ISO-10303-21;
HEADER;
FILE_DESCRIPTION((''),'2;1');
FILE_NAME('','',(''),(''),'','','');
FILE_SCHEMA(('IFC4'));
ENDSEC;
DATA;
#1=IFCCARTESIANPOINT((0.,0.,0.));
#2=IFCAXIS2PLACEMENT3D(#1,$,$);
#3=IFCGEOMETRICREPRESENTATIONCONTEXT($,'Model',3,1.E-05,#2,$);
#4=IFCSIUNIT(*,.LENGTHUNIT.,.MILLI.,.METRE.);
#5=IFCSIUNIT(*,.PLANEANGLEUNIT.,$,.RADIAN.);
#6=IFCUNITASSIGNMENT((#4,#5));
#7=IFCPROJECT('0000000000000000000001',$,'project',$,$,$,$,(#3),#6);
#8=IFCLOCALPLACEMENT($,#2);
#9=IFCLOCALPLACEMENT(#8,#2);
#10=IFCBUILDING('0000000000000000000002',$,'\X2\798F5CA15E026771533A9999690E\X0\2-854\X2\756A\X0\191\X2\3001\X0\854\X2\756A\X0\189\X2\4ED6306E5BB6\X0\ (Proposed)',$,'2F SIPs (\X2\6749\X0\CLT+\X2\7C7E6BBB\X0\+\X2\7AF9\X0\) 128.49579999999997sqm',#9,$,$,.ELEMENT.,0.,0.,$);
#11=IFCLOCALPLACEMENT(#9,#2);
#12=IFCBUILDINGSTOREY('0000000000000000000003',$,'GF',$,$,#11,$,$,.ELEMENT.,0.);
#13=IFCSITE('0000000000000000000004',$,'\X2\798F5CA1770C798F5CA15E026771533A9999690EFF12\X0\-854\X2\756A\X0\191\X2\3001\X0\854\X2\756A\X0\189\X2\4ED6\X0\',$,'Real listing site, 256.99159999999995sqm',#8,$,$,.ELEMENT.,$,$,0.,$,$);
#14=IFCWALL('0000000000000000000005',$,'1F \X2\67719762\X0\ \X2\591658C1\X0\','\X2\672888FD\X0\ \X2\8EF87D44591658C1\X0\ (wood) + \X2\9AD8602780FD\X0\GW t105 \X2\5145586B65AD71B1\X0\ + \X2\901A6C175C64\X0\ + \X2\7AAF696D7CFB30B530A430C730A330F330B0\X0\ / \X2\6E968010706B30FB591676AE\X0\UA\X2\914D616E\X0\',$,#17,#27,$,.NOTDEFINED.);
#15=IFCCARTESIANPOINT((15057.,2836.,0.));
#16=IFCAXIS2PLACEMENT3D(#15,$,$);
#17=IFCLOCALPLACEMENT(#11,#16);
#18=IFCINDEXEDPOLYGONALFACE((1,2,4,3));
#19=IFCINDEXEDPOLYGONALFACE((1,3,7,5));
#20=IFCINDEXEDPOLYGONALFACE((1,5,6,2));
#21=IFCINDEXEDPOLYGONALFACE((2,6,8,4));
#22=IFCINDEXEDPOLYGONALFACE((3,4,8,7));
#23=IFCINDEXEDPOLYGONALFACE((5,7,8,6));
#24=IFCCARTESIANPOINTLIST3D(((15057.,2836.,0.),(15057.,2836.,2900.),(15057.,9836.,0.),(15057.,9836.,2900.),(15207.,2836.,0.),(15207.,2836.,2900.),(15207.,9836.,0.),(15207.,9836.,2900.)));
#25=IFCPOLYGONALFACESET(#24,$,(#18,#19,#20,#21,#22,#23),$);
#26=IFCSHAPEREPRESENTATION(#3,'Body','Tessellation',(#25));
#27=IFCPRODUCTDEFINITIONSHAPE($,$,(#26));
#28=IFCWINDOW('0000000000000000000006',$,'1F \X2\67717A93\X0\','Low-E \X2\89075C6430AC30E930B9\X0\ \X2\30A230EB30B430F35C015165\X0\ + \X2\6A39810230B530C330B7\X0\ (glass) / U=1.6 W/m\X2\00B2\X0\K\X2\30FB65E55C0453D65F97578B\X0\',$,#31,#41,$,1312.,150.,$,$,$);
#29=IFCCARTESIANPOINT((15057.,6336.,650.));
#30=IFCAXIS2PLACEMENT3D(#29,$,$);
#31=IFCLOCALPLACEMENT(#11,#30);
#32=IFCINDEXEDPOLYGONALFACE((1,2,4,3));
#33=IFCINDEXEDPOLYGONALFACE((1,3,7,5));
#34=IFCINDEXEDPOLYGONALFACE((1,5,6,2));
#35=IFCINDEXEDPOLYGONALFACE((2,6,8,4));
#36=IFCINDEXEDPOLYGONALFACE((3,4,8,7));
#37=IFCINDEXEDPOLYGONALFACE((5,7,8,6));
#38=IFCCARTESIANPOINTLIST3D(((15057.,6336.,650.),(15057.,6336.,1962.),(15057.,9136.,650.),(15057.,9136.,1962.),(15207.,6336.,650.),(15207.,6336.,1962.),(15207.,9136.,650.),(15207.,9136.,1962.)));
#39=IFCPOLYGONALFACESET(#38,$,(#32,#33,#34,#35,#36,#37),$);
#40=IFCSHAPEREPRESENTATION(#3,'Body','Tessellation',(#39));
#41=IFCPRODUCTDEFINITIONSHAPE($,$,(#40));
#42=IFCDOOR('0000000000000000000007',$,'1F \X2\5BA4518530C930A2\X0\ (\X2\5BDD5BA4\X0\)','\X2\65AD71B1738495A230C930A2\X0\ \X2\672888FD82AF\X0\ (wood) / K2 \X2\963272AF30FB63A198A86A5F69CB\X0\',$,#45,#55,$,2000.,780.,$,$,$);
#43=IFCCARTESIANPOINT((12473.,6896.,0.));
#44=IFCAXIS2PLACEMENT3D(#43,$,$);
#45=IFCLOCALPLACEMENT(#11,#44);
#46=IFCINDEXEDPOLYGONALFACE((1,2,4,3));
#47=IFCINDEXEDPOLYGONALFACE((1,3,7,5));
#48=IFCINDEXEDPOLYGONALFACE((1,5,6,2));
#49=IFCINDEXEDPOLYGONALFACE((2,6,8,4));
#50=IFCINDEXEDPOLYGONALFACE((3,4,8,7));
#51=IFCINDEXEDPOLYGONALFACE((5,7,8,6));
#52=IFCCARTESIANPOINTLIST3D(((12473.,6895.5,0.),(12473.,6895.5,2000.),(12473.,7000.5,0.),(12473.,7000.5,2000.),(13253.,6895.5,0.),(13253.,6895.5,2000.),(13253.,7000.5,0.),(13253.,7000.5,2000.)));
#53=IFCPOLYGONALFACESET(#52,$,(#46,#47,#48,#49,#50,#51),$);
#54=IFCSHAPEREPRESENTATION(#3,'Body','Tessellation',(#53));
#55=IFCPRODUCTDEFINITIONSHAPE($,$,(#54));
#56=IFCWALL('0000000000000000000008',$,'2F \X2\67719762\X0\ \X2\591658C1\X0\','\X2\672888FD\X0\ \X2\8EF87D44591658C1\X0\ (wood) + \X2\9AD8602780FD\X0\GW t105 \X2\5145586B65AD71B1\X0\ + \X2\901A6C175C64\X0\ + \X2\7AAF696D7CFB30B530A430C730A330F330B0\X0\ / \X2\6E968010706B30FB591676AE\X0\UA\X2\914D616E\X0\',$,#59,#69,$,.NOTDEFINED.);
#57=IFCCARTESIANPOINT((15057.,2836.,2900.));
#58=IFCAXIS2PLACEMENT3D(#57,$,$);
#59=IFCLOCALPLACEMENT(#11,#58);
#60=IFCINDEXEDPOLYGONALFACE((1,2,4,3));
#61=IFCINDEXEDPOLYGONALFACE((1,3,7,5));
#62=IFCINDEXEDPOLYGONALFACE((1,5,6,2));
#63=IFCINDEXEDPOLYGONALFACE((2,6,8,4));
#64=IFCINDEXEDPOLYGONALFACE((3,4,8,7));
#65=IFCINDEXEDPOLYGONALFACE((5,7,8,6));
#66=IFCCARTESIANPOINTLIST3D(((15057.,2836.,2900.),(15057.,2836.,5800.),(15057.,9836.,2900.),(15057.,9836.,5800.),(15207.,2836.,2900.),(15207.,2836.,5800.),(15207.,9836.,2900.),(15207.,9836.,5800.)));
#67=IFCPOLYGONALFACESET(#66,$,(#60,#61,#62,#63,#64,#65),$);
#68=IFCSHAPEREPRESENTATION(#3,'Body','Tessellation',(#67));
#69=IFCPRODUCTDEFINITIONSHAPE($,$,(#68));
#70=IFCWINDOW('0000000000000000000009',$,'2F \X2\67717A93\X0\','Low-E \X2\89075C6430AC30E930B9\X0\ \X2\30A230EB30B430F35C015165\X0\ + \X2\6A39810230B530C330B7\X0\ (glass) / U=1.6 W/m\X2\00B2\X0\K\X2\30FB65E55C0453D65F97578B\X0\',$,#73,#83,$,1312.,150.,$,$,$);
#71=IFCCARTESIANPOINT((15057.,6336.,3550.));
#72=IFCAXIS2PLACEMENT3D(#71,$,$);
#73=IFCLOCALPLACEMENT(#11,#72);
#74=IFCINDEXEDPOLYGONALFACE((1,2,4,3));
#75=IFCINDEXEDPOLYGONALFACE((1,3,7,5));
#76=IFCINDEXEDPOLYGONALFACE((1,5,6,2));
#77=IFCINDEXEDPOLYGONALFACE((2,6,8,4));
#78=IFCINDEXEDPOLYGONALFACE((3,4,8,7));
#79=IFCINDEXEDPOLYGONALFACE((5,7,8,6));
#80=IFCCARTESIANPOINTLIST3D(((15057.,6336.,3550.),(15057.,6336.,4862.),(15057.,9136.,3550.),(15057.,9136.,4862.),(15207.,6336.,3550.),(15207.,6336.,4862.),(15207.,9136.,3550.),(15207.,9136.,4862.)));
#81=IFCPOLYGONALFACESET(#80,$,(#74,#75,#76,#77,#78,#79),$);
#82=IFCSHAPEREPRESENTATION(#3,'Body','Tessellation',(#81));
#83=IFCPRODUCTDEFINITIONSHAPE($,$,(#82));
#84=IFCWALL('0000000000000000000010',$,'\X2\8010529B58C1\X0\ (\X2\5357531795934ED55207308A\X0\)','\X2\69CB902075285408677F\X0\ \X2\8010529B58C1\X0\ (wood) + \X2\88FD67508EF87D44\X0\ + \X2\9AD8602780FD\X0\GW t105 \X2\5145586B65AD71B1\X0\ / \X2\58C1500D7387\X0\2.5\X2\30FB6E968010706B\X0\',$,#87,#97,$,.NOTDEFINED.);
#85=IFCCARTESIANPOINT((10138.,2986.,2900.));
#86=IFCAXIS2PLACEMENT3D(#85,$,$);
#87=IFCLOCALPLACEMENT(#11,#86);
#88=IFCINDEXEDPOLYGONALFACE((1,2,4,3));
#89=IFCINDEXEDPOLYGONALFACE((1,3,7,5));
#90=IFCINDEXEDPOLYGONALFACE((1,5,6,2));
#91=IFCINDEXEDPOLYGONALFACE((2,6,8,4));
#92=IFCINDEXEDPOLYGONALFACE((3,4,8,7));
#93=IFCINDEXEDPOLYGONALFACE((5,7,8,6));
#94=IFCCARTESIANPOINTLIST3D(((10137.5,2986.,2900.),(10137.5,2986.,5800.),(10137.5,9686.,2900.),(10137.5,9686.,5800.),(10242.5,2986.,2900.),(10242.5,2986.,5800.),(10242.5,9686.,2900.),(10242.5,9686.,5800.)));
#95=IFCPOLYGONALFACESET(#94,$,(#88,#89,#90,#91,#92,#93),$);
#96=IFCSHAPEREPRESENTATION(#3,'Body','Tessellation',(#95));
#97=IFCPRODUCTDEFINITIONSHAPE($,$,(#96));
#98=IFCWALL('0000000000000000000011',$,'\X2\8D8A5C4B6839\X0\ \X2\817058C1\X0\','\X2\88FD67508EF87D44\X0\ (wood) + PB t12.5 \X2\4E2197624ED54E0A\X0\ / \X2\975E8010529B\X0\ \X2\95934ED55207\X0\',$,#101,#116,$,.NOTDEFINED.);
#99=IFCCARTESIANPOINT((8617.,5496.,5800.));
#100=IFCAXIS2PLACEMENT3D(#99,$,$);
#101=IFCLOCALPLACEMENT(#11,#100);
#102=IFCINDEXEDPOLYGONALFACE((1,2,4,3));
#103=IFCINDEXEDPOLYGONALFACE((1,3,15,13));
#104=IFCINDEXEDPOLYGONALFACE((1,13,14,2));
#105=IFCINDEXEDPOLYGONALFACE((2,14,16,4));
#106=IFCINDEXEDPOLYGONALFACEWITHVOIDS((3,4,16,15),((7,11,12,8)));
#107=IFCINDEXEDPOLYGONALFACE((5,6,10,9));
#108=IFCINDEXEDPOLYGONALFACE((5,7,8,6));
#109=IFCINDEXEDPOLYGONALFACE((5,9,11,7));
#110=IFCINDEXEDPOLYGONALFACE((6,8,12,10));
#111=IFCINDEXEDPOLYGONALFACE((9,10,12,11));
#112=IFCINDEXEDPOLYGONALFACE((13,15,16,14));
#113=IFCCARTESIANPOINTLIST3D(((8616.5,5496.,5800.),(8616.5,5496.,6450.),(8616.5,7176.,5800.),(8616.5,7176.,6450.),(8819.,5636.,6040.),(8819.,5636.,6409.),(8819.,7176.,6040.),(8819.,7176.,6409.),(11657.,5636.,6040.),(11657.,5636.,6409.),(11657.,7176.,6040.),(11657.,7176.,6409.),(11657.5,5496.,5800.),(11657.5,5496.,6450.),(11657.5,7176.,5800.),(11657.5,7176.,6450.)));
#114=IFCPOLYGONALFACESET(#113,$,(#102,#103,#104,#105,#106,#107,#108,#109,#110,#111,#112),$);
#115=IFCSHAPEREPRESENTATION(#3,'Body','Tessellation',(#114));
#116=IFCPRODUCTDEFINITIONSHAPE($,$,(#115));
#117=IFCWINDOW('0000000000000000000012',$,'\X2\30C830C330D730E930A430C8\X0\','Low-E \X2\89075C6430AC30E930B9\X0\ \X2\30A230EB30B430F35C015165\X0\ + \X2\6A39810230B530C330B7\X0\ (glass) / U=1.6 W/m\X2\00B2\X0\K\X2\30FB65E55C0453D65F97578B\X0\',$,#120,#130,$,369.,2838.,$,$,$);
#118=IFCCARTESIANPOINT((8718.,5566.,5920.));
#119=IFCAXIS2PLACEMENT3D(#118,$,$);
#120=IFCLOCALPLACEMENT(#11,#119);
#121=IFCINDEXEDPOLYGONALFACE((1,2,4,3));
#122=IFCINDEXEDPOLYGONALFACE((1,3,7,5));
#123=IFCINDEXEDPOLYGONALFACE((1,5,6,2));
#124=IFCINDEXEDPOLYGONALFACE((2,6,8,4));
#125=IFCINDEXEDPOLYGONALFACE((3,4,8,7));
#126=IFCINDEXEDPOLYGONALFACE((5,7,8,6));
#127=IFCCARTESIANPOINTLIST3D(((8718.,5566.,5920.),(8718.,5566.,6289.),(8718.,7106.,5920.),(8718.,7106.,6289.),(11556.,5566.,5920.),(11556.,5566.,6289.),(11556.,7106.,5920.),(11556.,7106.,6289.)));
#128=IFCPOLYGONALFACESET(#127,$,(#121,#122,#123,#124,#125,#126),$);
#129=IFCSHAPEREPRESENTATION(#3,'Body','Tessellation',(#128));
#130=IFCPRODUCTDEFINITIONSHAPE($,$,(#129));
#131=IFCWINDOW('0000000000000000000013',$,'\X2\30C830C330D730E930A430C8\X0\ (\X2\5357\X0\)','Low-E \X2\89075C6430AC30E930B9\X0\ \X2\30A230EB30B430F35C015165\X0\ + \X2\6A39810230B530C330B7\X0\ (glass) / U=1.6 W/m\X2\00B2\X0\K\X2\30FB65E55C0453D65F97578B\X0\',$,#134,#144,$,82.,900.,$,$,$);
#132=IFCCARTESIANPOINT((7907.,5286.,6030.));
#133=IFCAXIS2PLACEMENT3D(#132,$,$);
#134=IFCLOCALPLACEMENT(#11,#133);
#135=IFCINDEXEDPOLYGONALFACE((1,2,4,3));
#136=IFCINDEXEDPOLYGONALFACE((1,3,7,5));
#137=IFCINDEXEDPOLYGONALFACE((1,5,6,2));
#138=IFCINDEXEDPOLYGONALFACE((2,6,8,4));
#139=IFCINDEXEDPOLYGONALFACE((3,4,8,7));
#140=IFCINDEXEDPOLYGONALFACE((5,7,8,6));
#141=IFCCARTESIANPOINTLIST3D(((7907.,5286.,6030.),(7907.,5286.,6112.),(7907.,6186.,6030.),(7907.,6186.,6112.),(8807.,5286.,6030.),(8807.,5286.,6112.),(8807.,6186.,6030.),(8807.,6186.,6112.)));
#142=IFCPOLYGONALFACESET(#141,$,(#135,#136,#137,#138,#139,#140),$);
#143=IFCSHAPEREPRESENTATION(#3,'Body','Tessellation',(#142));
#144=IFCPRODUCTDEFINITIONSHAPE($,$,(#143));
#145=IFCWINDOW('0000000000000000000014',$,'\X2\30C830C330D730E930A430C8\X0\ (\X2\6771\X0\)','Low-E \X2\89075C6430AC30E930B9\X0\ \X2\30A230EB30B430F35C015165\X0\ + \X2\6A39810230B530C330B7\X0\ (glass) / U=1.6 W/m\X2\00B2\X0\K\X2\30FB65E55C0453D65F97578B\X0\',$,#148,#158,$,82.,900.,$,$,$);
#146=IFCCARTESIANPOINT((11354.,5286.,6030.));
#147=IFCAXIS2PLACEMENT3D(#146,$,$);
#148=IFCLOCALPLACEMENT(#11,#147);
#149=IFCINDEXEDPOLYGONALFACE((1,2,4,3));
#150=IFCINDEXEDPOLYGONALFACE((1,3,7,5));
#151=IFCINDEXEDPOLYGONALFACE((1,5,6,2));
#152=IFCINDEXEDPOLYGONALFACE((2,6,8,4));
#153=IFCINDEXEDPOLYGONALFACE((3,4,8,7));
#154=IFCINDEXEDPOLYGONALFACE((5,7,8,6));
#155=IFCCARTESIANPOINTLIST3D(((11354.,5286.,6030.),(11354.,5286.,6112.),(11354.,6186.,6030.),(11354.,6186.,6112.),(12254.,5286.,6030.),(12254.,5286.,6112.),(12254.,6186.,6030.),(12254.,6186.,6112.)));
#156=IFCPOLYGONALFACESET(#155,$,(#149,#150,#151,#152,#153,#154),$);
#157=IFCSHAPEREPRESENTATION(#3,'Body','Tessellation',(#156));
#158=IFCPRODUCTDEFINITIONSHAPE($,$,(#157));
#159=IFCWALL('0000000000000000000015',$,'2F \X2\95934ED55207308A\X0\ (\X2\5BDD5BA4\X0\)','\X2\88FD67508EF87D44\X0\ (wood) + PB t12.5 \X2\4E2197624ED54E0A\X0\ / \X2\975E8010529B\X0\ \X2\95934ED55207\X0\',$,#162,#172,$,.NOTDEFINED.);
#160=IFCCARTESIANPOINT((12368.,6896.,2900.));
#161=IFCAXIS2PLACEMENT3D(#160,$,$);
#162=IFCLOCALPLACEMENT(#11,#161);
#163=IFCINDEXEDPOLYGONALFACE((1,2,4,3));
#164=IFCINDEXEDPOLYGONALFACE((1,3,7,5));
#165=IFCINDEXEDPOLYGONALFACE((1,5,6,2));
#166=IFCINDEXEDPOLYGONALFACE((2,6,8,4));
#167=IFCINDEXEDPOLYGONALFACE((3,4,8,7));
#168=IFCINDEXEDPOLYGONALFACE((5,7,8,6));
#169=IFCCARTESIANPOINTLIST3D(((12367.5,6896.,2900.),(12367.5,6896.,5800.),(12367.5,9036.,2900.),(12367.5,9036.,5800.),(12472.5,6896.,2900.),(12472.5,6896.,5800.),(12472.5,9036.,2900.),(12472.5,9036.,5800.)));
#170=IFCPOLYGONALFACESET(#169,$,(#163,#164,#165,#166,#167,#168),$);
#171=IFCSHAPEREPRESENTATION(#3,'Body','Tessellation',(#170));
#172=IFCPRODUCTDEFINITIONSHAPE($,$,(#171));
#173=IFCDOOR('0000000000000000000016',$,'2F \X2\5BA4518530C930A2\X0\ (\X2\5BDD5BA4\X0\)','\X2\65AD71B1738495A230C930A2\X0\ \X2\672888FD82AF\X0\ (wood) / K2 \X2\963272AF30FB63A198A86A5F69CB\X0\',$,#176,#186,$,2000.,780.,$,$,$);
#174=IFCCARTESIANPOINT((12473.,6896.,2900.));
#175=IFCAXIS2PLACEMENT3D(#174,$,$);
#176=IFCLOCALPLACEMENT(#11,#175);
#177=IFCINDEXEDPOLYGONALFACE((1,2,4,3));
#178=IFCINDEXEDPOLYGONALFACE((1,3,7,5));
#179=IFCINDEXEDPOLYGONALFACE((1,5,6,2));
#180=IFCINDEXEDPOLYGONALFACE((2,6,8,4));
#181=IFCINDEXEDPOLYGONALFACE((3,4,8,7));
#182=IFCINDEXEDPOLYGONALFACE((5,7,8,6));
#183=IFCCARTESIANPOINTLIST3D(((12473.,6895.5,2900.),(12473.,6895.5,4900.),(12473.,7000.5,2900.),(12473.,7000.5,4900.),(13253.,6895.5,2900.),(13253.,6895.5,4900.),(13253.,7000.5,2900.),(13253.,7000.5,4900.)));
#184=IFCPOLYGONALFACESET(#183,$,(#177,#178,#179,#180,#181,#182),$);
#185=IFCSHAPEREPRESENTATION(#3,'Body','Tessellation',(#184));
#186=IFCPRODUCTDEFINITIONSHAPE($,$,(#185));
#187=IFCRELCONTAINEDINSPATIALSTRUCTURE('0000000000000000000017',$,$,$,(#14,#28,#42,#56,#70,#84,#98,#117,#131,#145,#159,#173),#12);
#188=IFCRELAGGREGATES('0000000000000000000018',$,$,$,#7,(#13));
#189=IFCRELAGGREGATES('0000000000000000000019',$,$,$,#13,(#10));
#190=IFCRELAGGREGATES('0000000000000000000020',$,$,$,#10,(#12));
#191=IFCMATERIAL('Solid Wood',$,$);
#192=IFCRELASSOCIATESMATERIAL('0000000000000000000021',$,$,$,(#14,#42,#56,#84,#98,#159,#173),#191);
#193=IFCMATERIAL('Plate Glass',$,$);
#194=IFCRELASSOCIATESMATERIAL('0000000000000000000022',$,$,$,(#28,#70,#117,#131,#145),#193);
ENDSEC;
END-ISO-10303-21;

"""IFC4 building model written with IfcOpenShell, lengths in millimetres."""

from ifc_helpers import new_model, si_unit, frame, frame_2d, origin, place, context, project, spatial, rectangle, extrude, material, element, fill, save


model = new_model("IFC4")

# Units and contexts
model_context = context("Model", 3, precision=1e-05, world=origin())
ifc_project = project(units=[si_unit("LENGTHUNIT", "METRE", prefix="MILLI"), si_unit("PLANEANGLEUNIT", "RADIAN")], contexts=[model_context])

# Site, building, storey
site_placement = place(None, origin())
site = spatial("IfcSite", under=ifc_project, at=site_placement, Name="福岡県福岡市東区香椎２-854番191、854番189他", ObjectType="Real listing site, 256.99159999999995sqm", CompositionType="ELEMENT", RefElevation=0.0)
building_placement = place(site_placement, origin())
building = spatial("IfcBuilding", under=site, at=building_placement, Name="福岡市東区香椎2-854番191、854番189他の家 (Proposed)", ObjectType="2F SIPs (杉CLT+籾殻+竹) 128.49579999999997sqm", CompositionType="ELEMENT", ElevationOfRefHeight=0.0, ElevationOfTerrain=0.0)
storey_placement = place(building_placement, origin())
storey = spatial("IfcBuildingStorey", under=building, at=storey_placement, Name="GF", CompositionType="ELEMENT", Elevation=0.0)

# Wall, opening, window
ifc_material_1 = material(Name="Solid Wood")
wall_1_placement = place(storey_placement, frame((15057.0, 2836.0, 0.0)))
wall_1 = element("IfcWall", 1, at=wall_1_placement, inside=storey, material=ifc_material_1, Name="1F 東面 外壁", Description="木製 軸組外壁 (wood) + 高性能GW t105 充填断熱 + 通気層 + 窯業系サイディング / 準耐火・外皮UA配慮", PredefinedType="NOTDEFINED", context=model_context, shape_type="SweptSolid", body=[
    extrude(rectangle(XDim=150.0, YDim=7000.0, at=frame_2d((75.0, 3500.0))), frame((15057.0, 2836.0, 0.0)), (0.0, 0.0, 1.0), 2900.0),
])
opening_1_placement = place(storey_placement, frame((15057.0, 6336.0, 650.0)))
opening_1 = element("IfcOpeningElement", 2, at=opening_1_placement, cuts=wall_1, PredefinedType="NOTDEFINED", context=model_context, shape_type="SweptSolid", body=[
    extrude(rectangle(XDim=150.0, YDim=2800.0, at=frame_2d((75.0, 1400.0))), frame((15057.0, 6336.0, 650.0)), (0.0, 0.0, 1.0), 1312.0),
])
ifc_material_2 = material(Name="Plate Glass")
window_1_placement = place(storey_placement, frame((15057.0, 6336.0, 650.0)))
window_1 = element("IfcWindow", 3, at=window_1_placement, inside=storey, material=ifc_material_2, Name="1F 東窓", Description="Low-E 複層ガラス アルゴン封入 + 樹脂サッシ (glass) / U=1.6 W/m²K・日射取得型", OverallHeight=1312.0, OverallWidth=150.0, context=model_context, shape_type="SweptSolid", body=[
    extrude(rectangle(XDim=150.0, YDim=2800.0, at=frame_2d((75.0, 1400.0))), frame((15057.0, 6336.0, 650.0)), (0.0, 0.0, 1.0), 1312.0),
])
fill(opening_1, window_1)

# Door
door_1_placement = place(storey_placement, frame((12473.0, 6896.0, 0.0)))
element("IfcDoor", 4, at=door_1_placement, inside=storey, material=ifc_material_1, Name="1F 室内ドア (寝室)", Description="断熱玄関ドア 木製芯 (wood) / K2 防犯・採風機構", OverallHeight=2000.0, OverallWidth=780.0, context=model_context, shape_type="SweptSolid", body=[
    extrude(rectangle(XDim=780.0, YDim=105.0, at=frame_2d((390.0, 52.0))), frame((12473.0, 6896.0, 0.0)), (0.0, 0.0, 1.0), 2000.0),
])

# Wall, opening, window
wall_2_placement = place(storey_placement, frame((15057.0, 2836.0, 2900.0)))
wall_2 = element("IfcWall", 5, at=wall_2_placement, inside=storey, material=ifc_material_1, Name="2F 東面 外壁", Description="木製 軸組外壁 (wood) + 高性能GW t105 充填断熱 + 通気層 + 窯業系サイディング / 準耐火・外皮UA配慮", PredefinedType="NOTDEFINED", context=model_context, shape_type="SweptSolid", body=[
    extrude(rectangle(XDim=150.0, YDim=7000.0, at=frame_2d((75.0, 3500.0))), frame((15057.0, 2836.0, 2900.0)), (0.0, 0.0, 1.0), 2900.0),
])
opening_2_placement = place(storey_placement, frame((15057.0, 6336.0, 3550.0)))
opening_2 = element("IfcOpeningElement", 6, at=opening_2_placement, cuts=wall_2, PredefinedType="NOTDEFINED", context=model_context, shape_type="SweptSolid", body=[
    extrude(rectangle(XDim=150.0, YDim=2800.0, at=frame_2d((75.0, 1400.0))), frame((15057.0, 6336.0, 3550.0)), (0.0, 0.0, 1.0), 1312.0),
])
window_2_placement = place(storey_placement, frame((15057.0, 6336.0, 3550.0)))
window_2 = element("IfcWindow", 7, at=window_2_placement, inside=storey, material=ifc_material_2, Name="2F 東窓", Description="Low-E 複層ガラス アルゴン封入 + 樹脂サッシ (glass) / U=1.6 W/m²K・日射取得型", OverallHeight=1312.0, OverallWidth=150.0, context=model_context, shape_type="SweptSolid", body=[
    extrude(rectangle(XDim=150.0, YDim=2800.0, at=frame_2d((75.0, 1400.0))), frame((15057.0, 6336.0, 3550.0)), (0.0, 0.0, 1.0), 1312.0),
])
fill(opening_2, window_2)

# Wall
wall_3_placement = place(storey_placement, frame((10138.0, 2986.0, 2900.0)))
element("IfcWall", 8, at=wall_3_placement, inside=storey, material=ifc_material_1, Name="耐力壁 (南北間仕切り)", Description="構造用合板 耐力壁 (wood) + 製材軸組 + 高性能GW t105 充填断熱 / 壁倍率2.5・準耐火", PredefinedType="NOTDEFINED", context=model_context, shape_type="SweptSolid", body=[
    extrude(rectangle(XDim=105.0, YDim=6700.0, at=frame_2d((52.0, 3350.0))), frame((10138.0, 2986.0, 2900.0)), (0.0, 0.0, 1.0), 2900.0),
])

# Wall, openings, windows
wall_4_placement = place(storey_placement, frame((8617.0, 5496.0, 5800.0)))
wall_4 = element("IfcWall", 9, at=wall_4_placement, inside=storey, material=ifc_material_1, Name="越屋根 腰壁", Description="製材軸組 (wood) + PB t12.5 両面仕上 / 非耐力 間仕切", PredefinedType="NOTDEFINED", context=model_context, shape_type="SweptSolid", body=[
    extrude(rectangle(XDim=3041.0, YDim=1680.0, at=frame_2d((1520.0, 840.0))), frame((8617.0, 5496.0, 5800.0)), (0.0, 0.0, 1.0), 650.0),
])
opening_3_placement = place(storey_placement, frame((8718.0, 5566.0, 5920.0)))
opening_3 = element("IfcOpeningElement", 10, at=opening_3_placement, cuts=wall_4, PredefinedType="NOTDEFINED", context=model_context, shape_type="SweptSolid", body=[
    extrude(rectangle(XDim=2838.0, YDim=1540.0, at=frame_2d((1419.0, 770.0))), frame((8718.0, 5566.0, 5920.0)), (0.0, 0.0, 1.0), 369.0),
])
opening_4_placement = place(storey_placement, frame((7907.0, 5286.0, 6030.0)))
opening_4 = element("IfcOpeningElement", 11, at=opening_4_placement, cuts=wall_4, PredefinedType="NOTDEFINED", context=model_context, shape_type="SweptSolid", body=[
    extrude(rectangle(XDim=900.0, YDim=900.0, at=frame_2d((450.0, 450.0))), frame((7907.0, 5286.0, 6030.0)), (0.0, 0.0, 1.0), 82.0),
])
opening_5_placement = place(storey_placement, frame((11354.0, 5286.0, 6030.0)))
opening_5 = element("IfcOpeningElement", 12, at=opening_5_placement, cuts=wall_4, PredefinedType="NOTDEFINED", context=model_context, shape_type="SweptSolid", body=[
    extrude(rectangle(XDim=900.0, YDim=900.0, at=frame_2d((450.0, 450.0))), frame((11354.0, 5286.0, 6030.0)), (0.0, 0.0, 1.0), 82.0),
])
window_3_placement = place(storey_placement, frame((8718.0, 5566.0, 5920.0)))
window_3 = element("IfcWindow", 13, at=window_3_placement, inside=storey, material=ifc_material_2, Name="トップライト", Description="Low-E 複層ガラス アルゴン封入 + 樹脂サッシ (glass) / U=1.6 W/m²K・日射取得型", OverallHeight=369.0, OverallWidth=2838.0, context=model_context, shape_type="SweptSolid", body=[
    extrude(rectangle(XDim=2838.0, YDim=1540.0, at=frame_2d((1419.0, 770.0))), frame((8718.0, 5566.0, 5920.0)), (0.0, 0.0, 1.0), 369.0),
])
fill(opening_3, window_3)
window_4_placement = place(storey_placement, frame((7907.0, 5286.0, 6030.0)))
window_4 = element("IfcWindow", 14, at=window_4_placement, inside=storey, material=ifc_material_2, Name="トップライト (南)", Description="Low-E 複層ガラス アルゴン封入 + 樹脂サッシ (glass) / U=1.6 W/m²K・日射取得型", OverallHeight=82.0, OverallWidth=900.0, context=model_context, shape_type="SweptSolid", body=[
    extrude(rectangle(XDim=900.0, YDim=900.0, at=frame_2d((450.0, 450.0))), frame((7907.0, 5286.0, 6030.0)), (0.0, 0.0, 1.0), 82.0),
])
fill(opening_4, window_4)
window_5_placement = place(storey_placement, frame((11354.0, 5286.0, 6030.0)))
window_5 = element("IfcWindow", 15, at=window_5_placement, inside=storey, material=ifc_material_2, Name="トップライト (東)", Description="Low-E 複層ガラス アルゴン封入 + 樹脂サッシ (glass) / U=1.6 W/m²K・日射取得型", OverallHeight=82.0, OverallWidth=900.0, context=model_context, shape_type="SweptSolid", body=[
    extrude(rectangle(XDim=900.0, YDim=900.0, at=frame_2d((450.0, 450.0))), frame((11354.0, 5286.0, 6030.0)), (0.0, 0.0, 1.0), 82.0),
])
fill(opening_5, window_5)

# Wall
wall_5_placement = place(storey_placement, frame((12368.0, 6896.0, 2900.0)))
element("IfcWall", 16, at=wall_5_placement, inside=storey, material=ifc_material_1, Name="2F 間仕切り (寝室)", Description="製材軸組 (wood) + PB t12.5 両面仕上 / 非耐力 間仕切", PredefinedType="NOTDEFINED", context=model_context, shape_type="SweptSolid", body=[
    extrude(rectangle(XDim=105.0, YDim=2140.0, at=frame_2d((52.0, 1070.0))), frame((12368.0, 6896.0, 2900.0)), (0.0, 0.0, 1.0), 2900.0),
])

# Door
door_2_placement = place(storey_placement, frame((12473.0, 6896.0, 2900.0)))
element("IfcDoor", 17, at=door_2_placement, inside=storey, material=ifc_material_1, Name="2F 室内ドア (寝室)", Description="断熱玄関ドア 木製芯 (wood) / K2 防犯・採風機構", OverallHeight=2000.0, OverallWidth=780.0, context=model_context, shape_type="SweptSolid", body=[
    extrude(rectangle(XDim=780.0, YDim=105.0, at=frame_2d((390.0, 52.0))), frame((12473.0, 6896.0, 2900.0)), (0.0, 0.0, 1.0), 2000.0),
])

save(model, "model.ifc")
